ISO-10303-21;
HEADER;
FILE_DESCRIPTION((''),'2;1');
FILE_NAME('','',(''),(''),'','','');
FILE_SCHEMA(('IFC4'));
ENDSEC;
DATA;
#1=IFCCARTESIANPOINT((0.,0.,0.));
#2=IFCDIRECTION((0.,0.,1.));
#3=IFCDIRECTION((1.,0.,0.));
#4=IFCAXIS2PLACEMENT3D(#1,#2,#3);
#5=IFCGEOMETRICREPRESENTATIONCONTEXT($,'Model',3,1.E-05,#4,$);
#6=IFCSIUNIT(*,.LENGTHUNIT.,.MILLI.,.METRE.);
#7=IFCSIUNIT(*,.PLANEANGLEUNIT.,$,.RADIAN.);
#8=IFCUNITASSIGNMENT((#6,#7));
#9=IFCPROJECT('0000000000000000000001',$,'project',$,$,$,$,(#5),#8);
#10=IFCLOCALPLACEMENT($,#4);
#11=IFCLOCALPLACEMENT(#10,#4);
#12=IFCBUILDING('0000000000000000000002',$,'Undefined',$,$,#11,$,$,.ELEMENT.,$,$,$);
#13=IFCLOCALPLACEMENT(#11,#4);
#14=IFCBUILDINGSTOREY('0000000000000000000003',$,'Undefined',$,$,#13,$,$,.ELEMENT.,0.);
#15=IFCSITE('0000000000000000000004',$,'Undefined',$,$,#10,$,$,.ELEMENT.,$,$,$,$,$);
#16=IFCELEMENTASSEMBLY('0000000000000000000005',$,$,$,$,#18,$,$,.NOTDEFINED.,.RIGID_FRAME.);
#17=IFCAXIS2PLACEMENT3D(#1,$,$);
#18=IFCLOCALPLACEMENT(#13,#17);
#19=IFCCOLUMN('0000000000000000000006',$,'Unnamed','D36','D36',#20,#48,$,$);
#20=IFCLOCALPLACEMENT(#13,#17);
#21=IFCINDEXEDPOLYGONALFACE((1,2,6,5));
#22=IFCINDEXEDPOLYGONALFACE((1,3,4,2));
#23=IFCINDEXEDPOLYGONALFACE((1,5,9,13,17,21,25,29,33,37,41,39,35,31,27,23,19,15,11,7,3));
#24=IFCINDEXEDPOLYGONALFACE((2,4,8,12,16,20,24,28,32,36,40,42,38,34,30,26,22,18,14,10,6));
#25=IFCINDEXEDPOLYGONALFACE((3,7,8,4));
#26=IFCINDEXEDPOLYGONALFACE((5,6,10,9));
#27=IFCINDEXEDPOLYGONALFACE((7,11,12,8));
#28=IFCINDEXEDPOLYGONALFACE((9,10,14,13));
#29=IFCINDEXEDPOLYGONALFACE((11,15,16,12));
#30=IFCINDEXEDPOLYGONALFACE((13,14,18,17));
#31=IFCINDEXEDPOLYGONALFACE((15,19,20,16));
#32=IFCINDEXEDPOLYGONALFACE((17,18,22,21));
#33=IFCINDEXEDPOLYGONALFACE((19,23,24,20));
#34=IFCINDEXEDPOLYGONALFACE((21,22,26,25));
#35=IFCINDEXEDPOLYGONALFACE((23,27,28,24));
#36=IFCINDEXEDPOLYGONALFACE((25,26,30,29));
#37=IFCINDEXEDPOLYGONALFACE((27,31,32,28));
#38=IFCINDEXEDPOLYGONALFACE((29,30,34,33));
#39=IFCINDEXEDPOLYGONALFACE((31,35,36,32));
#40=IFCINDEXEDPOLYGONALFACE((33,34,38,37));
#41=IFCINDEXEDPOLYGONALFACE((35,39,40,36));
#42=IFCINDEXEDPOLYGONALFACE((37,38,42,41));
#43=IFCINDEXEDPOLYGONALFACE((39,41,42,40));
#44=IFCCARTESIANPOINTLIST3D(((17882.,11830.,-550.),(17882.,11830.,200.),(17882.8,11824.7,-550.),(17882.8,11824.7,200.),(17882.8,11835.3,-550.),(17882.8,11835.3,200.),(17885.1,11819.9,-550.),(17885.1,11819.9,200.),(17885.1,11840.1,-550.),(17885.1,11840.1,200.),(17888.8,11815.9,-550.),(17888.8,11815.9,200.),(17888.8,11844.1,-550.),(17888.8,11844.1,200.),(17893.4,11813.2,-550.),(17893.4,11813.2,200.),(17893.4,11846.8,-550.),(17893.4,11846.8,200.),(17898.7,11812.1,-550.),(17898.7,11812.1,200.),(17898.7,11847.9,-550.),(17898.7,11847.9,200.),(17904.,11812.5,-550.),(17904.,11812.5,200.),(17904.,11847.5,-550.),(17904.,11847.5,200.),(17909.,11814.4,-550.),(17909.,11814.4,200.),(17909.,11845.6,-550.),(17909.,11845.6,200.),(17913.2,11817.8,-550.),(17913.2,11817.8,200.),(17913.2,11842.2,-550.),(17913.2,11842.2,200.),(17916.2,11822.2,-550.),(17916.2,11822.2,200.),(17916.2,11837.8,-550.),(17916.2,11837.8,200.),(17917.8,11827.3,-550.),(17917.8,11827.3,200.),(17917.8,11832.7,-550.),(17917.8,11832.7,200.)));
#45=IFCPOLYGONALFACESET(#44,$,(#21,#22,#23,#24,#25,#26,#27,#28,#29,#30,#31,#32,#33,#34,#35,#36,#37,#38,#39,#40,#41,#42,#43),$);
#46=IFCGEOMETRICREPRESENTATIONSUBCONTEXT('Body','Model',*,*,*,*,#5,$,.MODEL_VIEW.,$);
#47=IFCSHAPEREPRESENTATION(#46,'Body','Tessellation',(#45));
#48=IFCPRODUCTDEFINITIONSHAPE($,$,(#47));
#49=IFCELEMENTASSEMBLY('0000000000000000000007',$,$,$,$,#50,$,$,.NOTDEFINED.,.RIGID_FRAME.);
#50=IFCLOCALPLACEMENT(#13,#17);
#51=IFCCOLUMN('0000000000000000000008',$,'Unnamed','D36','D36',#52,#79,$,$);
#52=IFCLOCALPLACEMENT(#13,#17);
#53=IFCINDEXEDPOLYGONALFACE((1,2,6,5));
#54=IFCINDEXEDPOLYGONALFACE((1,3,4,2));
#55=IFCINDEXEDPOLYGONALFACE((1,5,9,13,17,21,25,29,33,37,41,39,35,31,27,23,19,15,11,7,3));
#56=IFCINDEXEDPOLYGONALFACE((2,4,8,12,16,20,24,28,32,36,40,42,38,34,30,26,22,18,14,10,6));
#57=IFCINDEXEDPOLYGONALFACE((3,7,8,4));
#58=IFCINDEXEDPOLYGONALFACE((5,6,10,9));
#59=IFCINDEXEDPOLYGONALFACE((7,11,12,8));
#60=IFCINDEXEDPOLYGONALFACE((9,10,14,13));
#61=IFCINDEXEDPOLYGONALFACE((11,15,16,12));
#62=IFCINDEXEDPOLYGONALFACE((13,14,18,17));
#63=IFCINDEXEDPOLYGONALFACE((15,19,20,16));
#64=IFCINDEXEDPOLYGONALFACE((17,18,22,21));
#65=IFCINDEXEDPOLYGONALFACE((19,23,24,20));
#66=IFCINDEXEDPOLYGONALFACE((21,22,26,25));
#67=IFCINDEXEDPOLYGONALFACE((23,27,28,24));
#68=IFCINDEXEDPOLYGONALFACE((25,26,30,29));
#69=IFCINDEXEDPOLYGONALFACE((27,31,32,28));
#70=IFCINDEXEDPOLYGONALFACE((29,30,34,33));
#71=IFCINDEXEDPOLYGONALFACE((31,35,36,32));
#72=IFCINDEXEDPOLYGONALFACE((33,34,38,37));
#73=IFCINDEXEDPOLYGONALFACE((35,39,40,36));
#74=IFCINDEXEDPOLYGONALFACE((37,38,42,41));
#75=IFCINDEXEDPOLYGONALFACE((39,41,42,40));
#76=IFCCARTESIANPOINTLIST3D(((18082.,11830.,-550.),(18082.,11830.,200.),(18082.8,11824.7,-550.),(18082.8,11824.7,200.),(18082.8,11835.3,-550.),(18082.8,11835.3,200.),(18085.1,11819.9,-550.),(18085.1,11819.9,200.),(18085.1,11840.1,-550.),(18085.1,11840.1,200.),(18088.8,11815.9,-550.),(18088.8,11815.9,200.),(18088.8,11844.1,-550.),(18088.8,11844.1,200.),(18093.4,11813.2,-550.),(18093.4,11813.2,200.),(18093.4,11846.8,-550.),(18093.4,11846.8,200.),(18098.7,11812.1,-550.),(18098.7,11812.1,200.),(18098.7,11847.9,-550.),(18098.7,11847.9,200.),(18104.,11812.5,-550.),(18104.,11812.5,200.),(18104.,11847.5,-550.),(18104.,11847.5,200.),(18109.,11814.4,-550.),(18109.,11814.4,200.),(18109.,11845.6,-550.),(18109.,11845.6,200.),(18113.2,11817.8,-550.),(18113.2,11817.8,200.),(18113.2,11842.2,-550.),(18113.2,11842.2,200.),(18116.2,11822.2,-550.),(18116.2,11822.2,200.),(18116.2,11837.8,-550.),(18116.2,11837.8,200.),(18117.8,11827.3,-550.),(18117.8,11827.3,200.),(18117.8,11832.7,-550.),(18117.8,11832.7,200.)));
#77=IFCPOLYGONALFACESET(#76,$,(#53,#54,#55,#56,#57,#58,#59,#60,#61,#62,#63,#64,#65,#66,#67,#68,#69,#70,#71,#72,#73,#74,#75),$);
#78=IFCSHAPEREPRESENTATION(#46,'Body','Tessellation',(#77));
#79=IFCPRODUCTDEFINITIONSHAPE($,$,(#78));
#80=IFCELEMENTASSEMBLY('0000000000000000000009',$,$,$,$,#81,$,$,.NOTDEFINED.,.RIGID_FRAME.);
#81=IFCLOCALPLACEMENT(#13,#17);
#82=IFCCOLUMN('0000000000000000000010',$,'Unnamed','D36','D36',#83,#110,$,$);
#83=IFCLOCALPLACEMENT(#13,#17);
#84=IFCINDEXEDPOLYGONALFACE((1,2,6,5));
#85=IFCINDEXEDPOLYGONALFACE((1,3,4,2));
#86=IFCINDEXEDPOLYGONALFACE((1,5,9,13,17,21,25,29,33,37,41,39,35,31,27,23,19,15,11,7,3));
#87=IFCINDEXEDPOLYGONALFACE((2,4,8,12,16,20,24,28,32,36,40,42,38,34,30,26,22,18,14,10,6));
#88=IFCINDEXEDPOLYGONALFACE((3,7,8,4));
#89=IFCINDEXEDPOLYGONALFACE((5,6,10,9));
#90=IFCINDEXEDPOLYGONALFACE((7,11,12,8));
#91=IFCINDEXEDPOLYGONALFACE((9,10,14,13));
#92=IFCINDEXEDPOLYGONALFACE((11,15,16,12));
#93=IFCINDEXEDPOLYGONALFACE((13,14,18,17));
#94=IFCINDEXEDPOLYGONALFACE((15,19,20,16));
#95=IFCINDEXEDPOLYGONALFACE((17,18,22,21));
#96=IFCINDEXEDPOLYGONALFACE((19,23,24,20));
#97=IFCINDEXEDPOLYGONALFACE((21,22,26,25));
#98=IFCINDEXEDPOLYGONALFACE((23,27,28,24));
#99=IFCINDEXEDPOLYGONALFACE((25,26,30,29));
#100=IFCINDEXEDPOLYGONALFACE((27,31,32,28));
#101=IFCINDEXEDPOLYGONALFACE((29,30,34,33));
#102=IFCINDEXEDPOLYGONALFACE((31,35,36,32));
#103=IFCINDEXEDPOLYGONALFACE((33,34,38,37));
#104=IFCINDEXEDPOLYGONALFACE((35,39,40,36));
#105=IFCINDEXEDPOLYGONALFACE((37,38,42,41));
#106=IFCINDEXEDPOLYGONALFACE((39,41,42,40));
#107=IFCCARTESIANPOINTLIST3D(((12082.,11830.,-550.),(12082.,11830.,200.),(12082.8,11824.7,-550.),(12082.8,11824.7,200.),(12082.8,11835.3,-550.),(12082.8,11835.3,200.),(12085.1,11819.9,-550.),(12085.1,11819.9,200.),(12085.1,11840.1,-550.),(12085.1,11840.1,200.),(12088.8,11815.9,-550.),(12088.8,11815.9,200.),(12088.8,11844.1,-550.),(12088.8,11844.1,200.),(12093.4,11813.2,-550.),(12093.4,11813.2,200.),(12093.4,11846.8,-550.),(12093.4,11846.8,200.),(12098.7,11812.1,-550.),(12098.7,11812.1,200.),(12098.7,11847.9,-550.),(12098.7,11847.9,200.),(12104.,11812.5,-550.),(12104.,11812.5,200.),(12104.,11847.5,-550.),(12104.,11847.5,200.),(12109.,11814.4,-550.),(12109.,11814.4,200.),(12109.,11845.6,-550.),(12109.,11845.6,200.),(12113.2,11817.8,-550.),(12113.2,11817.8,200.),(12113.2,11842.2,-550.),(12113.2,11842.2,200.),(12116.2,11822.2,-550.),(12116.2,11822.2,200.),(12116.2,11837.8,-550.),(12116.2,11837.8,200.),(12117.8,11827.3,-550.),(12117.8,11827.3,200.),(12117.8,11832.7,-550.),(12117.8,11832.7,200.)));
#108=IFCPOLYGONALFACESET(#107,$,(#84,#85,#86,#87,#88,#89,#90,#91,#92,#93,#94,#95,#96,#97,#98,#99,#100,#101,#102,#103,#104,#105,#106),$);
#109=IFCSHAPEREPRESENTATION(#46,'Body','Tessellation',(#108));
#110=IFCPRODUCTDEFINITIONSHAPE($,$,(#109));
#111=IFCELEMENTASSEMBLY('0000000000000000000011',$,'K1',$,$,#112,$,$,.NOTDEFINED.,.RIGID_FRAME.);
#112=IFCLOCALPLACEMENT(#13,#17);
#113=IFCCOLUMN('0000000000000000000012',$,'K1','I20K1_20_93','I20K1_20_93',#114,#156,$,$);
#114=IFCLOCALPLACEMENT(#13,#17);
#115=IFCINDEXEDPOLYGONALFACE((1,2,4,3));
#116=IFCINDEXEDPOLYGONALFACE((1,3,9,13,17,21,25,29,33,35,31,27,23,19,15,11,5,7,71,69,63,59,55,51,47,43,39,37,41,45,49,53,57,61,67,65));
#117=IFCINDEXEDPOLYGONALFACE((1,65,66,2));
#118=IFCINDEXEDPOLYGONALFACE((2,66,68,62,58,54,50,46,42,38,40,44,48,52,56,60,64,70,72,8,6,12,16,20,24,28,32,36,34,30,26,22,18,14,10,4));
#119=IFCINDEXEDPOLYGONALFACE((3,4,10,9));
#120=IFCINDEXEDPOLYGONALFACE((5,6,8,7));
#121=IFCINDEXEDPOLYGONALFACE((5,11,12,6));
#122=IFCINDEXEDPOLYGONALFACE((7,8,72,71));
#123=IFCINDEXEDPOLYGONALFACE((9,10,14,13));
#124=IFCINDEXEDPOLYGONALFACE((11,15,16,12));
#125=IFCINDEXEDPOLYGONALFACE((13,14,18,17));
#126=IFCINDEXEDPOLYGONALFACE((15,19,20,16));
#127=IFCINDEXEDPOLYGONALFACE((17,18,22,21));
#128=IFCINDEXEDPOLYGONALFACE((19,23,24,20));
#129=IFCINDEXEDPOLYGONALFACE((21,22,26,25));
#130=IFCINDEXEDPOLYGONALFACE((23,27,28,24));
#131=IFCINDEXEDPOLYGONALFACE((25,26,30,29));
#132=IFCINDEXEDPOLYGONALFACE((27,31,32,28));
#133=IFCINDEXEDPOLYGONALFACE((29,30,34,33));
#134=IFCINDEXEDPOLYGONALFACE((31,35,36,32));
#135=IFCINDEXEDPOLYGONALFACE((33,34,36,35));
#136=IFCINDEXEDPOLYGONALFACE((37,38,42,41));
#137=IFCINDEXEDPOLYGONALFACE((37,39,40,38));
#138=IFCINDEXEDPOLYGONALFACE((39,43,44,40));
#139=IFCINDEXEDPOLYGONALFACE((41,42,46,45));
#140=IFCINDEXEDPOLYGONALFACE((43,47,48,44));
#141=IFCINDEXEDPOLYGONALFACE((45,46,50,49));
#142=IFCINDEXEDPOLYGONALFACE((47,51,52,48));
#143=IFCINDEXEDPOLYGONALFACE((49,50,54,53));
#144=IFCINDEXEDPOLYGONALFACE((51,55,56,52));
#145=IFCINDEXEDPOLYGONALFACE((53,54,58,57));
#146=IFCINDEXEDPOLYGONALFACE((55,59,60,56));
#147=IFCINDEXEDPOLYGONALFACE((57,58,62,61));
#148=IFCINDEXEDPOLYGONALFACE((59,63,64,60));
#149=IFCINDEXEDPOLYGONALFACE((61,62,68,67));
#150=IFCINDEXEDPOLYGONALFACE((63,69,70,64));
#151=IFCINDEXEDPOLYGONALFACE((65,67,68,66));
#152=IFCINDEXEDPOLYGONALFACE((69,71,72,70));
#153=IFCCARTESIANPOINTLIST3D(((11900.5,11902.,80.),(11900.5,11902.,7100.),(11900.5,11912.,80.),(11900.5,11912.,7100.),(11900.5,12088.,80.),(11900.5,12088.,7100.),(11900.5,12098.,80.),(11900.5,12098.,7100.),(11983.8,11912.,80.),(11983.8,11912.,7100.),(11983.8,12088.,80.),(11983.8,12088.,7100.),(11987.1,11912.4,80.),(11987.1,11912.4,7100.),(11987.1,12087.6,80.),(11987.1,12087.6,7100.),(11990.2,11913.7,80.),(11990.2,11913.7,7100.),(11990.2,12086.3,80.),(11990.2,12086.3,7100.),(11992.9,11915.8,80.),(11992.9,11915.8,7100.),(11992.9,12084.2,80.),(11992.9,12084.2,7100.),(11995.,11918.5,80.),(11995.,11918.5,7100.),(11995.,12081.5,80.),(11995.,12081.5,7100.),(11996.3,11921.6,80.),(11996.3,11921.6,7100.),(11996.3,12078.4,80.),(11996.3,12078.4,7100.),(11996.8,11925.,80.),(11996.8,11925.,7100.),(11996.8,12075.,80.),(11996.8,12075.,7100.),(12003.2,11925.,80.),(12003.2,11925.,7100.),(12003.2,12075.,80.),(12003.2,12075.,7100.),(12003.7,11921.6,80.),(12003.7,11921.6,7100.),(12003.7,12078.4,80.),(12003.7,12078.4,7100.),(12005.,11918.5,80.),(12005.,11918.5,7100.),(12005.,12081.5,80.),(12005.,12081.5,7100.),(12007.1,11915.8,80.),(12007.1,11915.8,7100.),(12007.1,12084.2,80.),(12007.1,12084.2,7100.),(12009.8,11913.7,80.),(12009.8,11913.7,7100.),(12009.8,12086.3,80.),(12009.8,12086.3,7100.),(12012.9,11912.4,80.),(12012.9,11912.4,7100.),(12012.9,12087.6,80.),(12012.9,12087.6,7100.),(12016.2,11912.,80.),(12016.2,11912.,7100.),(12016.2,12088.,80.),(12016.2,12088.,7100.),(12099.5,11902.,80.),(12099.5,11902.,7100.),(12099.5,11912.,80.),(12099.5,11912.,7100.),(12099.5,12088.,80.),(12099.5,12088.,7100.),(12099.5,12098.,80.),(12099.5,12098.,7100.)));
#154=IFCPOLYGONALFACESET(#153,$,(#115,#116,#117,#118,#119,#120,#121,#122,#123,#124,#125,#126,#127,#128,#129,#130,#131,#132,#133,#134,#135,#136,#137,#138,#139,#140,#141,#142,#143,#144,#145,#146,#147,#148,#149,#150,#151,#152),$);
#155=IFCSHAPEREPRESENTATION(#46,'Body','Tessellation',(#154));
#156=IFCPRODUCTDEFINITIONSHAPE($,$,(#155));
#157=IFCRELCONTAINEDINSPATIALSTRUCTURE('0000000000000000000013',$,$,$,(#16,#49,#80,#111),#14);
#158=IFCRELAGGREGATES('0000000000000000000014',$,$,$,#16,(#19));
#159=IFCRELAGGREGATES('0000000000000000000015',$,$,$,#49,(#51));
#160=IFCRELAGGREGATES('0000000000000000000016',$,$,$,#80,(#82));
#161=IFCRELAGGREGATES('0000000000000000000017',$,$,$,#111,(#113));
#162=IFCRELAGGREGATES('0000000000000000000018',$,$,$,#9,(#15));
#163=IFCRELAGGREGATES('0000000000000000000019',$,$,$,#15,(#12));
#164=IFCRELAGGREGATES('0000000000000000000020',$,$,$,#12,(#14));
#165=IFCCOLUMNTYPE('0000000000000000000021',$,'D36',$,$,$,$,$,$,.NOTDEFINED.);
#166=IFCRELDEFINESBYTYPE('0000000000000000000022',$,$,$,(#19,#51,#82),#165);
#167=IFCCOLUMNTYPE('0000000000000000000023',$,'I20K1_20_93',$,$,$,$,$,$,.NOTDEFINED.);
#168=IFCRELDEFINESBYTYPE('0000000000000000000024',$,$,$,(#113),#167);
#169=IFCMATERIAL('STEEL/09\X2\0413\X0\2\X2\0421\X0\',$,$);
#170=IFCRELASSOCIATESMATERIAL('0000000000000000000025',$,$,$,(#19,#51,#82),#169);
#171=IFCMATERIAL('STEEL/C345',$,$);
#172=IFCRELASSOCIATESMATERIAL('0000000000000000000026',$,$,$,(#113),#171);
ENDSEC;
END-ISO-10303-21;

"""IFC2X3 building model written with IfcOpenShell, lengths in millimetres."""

from ifc_helpers import new_model, si_unit, frame, origin_with_axes, origin_2d_with_axis, place, context, subcontext, project, spatial, circle, i_section, extrude, material, type_object, element, aggregate, save


model = new_model("IFC2X3")

# Units and contexts
model_context = context("Model", 3, precision=1e-05, world=origin_with_axes())
body_context = subcontext(model_context, "Body", "Model", "MODEL_VIEW")
ifc_project = project(units=[si_unit("LENGTHUNIT", "METRE", prefix="MILLI"), si_unit("PLANEANGLEUNIT", "RADIAN")], contexts=[model_context])

# Site, building, storey
site_placement = place(None, origin_with_axes())
site = spatial("IfcSite", under=ifc_project, at=site_placement, Name="Undefined", CompositionType="ELEMENT")
building_placement = place(site_placement, origin_with_axes())
building = spatial("IfcBuilding", under=site, at=building_placement, Name="Undefined", CompositionType="ELEMENT")
storey_placement = place(building_placement, origin_with_axes())
storey = spatial("IfcBuildingStorey", under=building, at=storey_placement, Name="Undefined", CompositionType="ELEMENT", Elevation=0.0)

# Element assemblies, columns
assembly_1_placement = place(storey_placement, origin_with_axes())
assembly_1 = element("IfcElementAssembly", 1, at=assembly_1_placement, inside=storey, AssemblyPlace="NOTDEFINED", PredefinedType="RIGID_FRAME")
ifc_material_1 = material(Name="STEEL/09Г2С")
column_type_1 = type_object("IfcColumnType", Name="D36", PredefinedType="NOTDEFINED")
column_1_placement = place(assembly_1_placement, frame((17900.0, 11830.0, -550.0), z_axis=(0.0, 0.0, 1.0), x_axis=(0.0, 1.0, 0.0)))
column_1 = element("IfcColumn", 2, at=column_1_placement, type_object=column_type_1, material=ifc_material_1, Name="Unnamed", Description="D36", ObjectType="D36", context=body_context, shape_type="SweptSolid", body=[
    extrude(circle(Radius=18.0, at=origin_2d_with_axis()), frame((0.0, 0.0, 750.0), z_axis=(0.0, 0.0, -1.0), x_axis=(0.0, 1.0, 0.0)), (0.0, 0.0, 1.0), 750.0),
])
aggregate(assembly_1, [column_1])
assembly_2_placement = place(storey_placement, origin_with_axes())
assembly_2 = element("IfcElementAssembly", 3, at=assembly_2_placement, inside=storey, AssemblyPlace="NOTDEFINED", PredefinedType="RIGID_FRAME")
column_2_placement = place(assembly_2_placement, frame((18100.0, 11830.0, -550.0), z_axis=(0.0, 0.0, 1.0), x_axis=(0.0, 1.0, 0.0)))
column_2 = element("IfcColumn", 4, at=column_2_placement, type_object=column_type_1, material=ifc_material_1, Name="Unnamed", Description="D36", ObjectType="D36", context=body_context, shape_type="SweptSolid", body=[
    extrude(circle(Radius=18.0, at=origin_2d_with_axis()), frame((0.0, 0.0, 750.0), z_axis=(0.0, 0.0, -1.0), x_axis=(0.0, 1.0, 0.0)), (0.0, 0.0, 1.0), 750.0),
])
aggregate(assembly_2, [column_2])
assembly_3_placement = place(storey_placement, origin_with_axes())
assembly_3 = element("IfcElementAssembly", 5, at=assembly_3_placement, inside=storey, AssemblyPlace="NOTDEFINED", PredefinedType="RIGID_FRAME")
column_3_placement = place(assembly_3_placement, frame((12100.0, 11830.0, -550.0), z_axis=(0.0, 0.0, 1.0), x_axis=(0.0, 1.0, 0.0)))
column_3 = element("IfcColumn", 6, at=column_3_placement, type_object=column_type_1, material=ifc_material_1, Name="Unnamed", Description="D36", ObjectType="D36", context=body_context, shape_type="SweptSolid", body=[
    extrude(circle(Radius=18.0, at=origin_2d_with_axis()), frame((0.0, 0.0, 750.0), z_axis=(0.0, 0.0, -1.0), x_axis=(0.0, 1.0, 0.0)), (0.0, 0.0, 1.0), 750.0),
])
aggregate(assembly_3, [column_3])
assembly_4_placement = place(storey_placement, origin_with_axes())
assembly_4 = element("IfcElementAssembly", 7, at=assembly_4_placement, inside=storey, Name="K1", AssemblyPlace="NOTDEFINED", PredefinedType="RIGID_FRAME")
ifc_material_2 = material(Name="STEEL/C345")
column_type_2 = type_object("IfcColumnType", Name="I20K1_20_93", PredefinedType="NOTDEFINED")
column_4_placement = place(assembly_4_placement, frame((12000.0, 12000.0, 80.0), z_axis=(0.0, 0.0, 1.0), x_axis=(0.0, 1.0, 0.0)))
column_4 = element("IfcColumn", 8, at=column_4_placement, type_object=column_type_2, material=ifc_material_2, Name="K1", Description="I20K1_20_93", ObjectType="I20K1_20_93", context=body_context, shape_type="SweptSolid", body=[
    extrude(i_section(OverallWidth=199.0, OverallDepth=196.0, WebThickness=6.5, FlangeThickness=10.0, FilletRadius=13.0, at=origin_2d_with_axis()), frame((0.0, 0.0, 7020.0), z_axis=(0.0, 0.0, -1.0), x_axis=(0.0, 1.0, 0.0)), (0.0, 0.0, 1.0), 7020.0),
])
aggregate(assembly_4, [column_4])

save(model, "model.ifc")
